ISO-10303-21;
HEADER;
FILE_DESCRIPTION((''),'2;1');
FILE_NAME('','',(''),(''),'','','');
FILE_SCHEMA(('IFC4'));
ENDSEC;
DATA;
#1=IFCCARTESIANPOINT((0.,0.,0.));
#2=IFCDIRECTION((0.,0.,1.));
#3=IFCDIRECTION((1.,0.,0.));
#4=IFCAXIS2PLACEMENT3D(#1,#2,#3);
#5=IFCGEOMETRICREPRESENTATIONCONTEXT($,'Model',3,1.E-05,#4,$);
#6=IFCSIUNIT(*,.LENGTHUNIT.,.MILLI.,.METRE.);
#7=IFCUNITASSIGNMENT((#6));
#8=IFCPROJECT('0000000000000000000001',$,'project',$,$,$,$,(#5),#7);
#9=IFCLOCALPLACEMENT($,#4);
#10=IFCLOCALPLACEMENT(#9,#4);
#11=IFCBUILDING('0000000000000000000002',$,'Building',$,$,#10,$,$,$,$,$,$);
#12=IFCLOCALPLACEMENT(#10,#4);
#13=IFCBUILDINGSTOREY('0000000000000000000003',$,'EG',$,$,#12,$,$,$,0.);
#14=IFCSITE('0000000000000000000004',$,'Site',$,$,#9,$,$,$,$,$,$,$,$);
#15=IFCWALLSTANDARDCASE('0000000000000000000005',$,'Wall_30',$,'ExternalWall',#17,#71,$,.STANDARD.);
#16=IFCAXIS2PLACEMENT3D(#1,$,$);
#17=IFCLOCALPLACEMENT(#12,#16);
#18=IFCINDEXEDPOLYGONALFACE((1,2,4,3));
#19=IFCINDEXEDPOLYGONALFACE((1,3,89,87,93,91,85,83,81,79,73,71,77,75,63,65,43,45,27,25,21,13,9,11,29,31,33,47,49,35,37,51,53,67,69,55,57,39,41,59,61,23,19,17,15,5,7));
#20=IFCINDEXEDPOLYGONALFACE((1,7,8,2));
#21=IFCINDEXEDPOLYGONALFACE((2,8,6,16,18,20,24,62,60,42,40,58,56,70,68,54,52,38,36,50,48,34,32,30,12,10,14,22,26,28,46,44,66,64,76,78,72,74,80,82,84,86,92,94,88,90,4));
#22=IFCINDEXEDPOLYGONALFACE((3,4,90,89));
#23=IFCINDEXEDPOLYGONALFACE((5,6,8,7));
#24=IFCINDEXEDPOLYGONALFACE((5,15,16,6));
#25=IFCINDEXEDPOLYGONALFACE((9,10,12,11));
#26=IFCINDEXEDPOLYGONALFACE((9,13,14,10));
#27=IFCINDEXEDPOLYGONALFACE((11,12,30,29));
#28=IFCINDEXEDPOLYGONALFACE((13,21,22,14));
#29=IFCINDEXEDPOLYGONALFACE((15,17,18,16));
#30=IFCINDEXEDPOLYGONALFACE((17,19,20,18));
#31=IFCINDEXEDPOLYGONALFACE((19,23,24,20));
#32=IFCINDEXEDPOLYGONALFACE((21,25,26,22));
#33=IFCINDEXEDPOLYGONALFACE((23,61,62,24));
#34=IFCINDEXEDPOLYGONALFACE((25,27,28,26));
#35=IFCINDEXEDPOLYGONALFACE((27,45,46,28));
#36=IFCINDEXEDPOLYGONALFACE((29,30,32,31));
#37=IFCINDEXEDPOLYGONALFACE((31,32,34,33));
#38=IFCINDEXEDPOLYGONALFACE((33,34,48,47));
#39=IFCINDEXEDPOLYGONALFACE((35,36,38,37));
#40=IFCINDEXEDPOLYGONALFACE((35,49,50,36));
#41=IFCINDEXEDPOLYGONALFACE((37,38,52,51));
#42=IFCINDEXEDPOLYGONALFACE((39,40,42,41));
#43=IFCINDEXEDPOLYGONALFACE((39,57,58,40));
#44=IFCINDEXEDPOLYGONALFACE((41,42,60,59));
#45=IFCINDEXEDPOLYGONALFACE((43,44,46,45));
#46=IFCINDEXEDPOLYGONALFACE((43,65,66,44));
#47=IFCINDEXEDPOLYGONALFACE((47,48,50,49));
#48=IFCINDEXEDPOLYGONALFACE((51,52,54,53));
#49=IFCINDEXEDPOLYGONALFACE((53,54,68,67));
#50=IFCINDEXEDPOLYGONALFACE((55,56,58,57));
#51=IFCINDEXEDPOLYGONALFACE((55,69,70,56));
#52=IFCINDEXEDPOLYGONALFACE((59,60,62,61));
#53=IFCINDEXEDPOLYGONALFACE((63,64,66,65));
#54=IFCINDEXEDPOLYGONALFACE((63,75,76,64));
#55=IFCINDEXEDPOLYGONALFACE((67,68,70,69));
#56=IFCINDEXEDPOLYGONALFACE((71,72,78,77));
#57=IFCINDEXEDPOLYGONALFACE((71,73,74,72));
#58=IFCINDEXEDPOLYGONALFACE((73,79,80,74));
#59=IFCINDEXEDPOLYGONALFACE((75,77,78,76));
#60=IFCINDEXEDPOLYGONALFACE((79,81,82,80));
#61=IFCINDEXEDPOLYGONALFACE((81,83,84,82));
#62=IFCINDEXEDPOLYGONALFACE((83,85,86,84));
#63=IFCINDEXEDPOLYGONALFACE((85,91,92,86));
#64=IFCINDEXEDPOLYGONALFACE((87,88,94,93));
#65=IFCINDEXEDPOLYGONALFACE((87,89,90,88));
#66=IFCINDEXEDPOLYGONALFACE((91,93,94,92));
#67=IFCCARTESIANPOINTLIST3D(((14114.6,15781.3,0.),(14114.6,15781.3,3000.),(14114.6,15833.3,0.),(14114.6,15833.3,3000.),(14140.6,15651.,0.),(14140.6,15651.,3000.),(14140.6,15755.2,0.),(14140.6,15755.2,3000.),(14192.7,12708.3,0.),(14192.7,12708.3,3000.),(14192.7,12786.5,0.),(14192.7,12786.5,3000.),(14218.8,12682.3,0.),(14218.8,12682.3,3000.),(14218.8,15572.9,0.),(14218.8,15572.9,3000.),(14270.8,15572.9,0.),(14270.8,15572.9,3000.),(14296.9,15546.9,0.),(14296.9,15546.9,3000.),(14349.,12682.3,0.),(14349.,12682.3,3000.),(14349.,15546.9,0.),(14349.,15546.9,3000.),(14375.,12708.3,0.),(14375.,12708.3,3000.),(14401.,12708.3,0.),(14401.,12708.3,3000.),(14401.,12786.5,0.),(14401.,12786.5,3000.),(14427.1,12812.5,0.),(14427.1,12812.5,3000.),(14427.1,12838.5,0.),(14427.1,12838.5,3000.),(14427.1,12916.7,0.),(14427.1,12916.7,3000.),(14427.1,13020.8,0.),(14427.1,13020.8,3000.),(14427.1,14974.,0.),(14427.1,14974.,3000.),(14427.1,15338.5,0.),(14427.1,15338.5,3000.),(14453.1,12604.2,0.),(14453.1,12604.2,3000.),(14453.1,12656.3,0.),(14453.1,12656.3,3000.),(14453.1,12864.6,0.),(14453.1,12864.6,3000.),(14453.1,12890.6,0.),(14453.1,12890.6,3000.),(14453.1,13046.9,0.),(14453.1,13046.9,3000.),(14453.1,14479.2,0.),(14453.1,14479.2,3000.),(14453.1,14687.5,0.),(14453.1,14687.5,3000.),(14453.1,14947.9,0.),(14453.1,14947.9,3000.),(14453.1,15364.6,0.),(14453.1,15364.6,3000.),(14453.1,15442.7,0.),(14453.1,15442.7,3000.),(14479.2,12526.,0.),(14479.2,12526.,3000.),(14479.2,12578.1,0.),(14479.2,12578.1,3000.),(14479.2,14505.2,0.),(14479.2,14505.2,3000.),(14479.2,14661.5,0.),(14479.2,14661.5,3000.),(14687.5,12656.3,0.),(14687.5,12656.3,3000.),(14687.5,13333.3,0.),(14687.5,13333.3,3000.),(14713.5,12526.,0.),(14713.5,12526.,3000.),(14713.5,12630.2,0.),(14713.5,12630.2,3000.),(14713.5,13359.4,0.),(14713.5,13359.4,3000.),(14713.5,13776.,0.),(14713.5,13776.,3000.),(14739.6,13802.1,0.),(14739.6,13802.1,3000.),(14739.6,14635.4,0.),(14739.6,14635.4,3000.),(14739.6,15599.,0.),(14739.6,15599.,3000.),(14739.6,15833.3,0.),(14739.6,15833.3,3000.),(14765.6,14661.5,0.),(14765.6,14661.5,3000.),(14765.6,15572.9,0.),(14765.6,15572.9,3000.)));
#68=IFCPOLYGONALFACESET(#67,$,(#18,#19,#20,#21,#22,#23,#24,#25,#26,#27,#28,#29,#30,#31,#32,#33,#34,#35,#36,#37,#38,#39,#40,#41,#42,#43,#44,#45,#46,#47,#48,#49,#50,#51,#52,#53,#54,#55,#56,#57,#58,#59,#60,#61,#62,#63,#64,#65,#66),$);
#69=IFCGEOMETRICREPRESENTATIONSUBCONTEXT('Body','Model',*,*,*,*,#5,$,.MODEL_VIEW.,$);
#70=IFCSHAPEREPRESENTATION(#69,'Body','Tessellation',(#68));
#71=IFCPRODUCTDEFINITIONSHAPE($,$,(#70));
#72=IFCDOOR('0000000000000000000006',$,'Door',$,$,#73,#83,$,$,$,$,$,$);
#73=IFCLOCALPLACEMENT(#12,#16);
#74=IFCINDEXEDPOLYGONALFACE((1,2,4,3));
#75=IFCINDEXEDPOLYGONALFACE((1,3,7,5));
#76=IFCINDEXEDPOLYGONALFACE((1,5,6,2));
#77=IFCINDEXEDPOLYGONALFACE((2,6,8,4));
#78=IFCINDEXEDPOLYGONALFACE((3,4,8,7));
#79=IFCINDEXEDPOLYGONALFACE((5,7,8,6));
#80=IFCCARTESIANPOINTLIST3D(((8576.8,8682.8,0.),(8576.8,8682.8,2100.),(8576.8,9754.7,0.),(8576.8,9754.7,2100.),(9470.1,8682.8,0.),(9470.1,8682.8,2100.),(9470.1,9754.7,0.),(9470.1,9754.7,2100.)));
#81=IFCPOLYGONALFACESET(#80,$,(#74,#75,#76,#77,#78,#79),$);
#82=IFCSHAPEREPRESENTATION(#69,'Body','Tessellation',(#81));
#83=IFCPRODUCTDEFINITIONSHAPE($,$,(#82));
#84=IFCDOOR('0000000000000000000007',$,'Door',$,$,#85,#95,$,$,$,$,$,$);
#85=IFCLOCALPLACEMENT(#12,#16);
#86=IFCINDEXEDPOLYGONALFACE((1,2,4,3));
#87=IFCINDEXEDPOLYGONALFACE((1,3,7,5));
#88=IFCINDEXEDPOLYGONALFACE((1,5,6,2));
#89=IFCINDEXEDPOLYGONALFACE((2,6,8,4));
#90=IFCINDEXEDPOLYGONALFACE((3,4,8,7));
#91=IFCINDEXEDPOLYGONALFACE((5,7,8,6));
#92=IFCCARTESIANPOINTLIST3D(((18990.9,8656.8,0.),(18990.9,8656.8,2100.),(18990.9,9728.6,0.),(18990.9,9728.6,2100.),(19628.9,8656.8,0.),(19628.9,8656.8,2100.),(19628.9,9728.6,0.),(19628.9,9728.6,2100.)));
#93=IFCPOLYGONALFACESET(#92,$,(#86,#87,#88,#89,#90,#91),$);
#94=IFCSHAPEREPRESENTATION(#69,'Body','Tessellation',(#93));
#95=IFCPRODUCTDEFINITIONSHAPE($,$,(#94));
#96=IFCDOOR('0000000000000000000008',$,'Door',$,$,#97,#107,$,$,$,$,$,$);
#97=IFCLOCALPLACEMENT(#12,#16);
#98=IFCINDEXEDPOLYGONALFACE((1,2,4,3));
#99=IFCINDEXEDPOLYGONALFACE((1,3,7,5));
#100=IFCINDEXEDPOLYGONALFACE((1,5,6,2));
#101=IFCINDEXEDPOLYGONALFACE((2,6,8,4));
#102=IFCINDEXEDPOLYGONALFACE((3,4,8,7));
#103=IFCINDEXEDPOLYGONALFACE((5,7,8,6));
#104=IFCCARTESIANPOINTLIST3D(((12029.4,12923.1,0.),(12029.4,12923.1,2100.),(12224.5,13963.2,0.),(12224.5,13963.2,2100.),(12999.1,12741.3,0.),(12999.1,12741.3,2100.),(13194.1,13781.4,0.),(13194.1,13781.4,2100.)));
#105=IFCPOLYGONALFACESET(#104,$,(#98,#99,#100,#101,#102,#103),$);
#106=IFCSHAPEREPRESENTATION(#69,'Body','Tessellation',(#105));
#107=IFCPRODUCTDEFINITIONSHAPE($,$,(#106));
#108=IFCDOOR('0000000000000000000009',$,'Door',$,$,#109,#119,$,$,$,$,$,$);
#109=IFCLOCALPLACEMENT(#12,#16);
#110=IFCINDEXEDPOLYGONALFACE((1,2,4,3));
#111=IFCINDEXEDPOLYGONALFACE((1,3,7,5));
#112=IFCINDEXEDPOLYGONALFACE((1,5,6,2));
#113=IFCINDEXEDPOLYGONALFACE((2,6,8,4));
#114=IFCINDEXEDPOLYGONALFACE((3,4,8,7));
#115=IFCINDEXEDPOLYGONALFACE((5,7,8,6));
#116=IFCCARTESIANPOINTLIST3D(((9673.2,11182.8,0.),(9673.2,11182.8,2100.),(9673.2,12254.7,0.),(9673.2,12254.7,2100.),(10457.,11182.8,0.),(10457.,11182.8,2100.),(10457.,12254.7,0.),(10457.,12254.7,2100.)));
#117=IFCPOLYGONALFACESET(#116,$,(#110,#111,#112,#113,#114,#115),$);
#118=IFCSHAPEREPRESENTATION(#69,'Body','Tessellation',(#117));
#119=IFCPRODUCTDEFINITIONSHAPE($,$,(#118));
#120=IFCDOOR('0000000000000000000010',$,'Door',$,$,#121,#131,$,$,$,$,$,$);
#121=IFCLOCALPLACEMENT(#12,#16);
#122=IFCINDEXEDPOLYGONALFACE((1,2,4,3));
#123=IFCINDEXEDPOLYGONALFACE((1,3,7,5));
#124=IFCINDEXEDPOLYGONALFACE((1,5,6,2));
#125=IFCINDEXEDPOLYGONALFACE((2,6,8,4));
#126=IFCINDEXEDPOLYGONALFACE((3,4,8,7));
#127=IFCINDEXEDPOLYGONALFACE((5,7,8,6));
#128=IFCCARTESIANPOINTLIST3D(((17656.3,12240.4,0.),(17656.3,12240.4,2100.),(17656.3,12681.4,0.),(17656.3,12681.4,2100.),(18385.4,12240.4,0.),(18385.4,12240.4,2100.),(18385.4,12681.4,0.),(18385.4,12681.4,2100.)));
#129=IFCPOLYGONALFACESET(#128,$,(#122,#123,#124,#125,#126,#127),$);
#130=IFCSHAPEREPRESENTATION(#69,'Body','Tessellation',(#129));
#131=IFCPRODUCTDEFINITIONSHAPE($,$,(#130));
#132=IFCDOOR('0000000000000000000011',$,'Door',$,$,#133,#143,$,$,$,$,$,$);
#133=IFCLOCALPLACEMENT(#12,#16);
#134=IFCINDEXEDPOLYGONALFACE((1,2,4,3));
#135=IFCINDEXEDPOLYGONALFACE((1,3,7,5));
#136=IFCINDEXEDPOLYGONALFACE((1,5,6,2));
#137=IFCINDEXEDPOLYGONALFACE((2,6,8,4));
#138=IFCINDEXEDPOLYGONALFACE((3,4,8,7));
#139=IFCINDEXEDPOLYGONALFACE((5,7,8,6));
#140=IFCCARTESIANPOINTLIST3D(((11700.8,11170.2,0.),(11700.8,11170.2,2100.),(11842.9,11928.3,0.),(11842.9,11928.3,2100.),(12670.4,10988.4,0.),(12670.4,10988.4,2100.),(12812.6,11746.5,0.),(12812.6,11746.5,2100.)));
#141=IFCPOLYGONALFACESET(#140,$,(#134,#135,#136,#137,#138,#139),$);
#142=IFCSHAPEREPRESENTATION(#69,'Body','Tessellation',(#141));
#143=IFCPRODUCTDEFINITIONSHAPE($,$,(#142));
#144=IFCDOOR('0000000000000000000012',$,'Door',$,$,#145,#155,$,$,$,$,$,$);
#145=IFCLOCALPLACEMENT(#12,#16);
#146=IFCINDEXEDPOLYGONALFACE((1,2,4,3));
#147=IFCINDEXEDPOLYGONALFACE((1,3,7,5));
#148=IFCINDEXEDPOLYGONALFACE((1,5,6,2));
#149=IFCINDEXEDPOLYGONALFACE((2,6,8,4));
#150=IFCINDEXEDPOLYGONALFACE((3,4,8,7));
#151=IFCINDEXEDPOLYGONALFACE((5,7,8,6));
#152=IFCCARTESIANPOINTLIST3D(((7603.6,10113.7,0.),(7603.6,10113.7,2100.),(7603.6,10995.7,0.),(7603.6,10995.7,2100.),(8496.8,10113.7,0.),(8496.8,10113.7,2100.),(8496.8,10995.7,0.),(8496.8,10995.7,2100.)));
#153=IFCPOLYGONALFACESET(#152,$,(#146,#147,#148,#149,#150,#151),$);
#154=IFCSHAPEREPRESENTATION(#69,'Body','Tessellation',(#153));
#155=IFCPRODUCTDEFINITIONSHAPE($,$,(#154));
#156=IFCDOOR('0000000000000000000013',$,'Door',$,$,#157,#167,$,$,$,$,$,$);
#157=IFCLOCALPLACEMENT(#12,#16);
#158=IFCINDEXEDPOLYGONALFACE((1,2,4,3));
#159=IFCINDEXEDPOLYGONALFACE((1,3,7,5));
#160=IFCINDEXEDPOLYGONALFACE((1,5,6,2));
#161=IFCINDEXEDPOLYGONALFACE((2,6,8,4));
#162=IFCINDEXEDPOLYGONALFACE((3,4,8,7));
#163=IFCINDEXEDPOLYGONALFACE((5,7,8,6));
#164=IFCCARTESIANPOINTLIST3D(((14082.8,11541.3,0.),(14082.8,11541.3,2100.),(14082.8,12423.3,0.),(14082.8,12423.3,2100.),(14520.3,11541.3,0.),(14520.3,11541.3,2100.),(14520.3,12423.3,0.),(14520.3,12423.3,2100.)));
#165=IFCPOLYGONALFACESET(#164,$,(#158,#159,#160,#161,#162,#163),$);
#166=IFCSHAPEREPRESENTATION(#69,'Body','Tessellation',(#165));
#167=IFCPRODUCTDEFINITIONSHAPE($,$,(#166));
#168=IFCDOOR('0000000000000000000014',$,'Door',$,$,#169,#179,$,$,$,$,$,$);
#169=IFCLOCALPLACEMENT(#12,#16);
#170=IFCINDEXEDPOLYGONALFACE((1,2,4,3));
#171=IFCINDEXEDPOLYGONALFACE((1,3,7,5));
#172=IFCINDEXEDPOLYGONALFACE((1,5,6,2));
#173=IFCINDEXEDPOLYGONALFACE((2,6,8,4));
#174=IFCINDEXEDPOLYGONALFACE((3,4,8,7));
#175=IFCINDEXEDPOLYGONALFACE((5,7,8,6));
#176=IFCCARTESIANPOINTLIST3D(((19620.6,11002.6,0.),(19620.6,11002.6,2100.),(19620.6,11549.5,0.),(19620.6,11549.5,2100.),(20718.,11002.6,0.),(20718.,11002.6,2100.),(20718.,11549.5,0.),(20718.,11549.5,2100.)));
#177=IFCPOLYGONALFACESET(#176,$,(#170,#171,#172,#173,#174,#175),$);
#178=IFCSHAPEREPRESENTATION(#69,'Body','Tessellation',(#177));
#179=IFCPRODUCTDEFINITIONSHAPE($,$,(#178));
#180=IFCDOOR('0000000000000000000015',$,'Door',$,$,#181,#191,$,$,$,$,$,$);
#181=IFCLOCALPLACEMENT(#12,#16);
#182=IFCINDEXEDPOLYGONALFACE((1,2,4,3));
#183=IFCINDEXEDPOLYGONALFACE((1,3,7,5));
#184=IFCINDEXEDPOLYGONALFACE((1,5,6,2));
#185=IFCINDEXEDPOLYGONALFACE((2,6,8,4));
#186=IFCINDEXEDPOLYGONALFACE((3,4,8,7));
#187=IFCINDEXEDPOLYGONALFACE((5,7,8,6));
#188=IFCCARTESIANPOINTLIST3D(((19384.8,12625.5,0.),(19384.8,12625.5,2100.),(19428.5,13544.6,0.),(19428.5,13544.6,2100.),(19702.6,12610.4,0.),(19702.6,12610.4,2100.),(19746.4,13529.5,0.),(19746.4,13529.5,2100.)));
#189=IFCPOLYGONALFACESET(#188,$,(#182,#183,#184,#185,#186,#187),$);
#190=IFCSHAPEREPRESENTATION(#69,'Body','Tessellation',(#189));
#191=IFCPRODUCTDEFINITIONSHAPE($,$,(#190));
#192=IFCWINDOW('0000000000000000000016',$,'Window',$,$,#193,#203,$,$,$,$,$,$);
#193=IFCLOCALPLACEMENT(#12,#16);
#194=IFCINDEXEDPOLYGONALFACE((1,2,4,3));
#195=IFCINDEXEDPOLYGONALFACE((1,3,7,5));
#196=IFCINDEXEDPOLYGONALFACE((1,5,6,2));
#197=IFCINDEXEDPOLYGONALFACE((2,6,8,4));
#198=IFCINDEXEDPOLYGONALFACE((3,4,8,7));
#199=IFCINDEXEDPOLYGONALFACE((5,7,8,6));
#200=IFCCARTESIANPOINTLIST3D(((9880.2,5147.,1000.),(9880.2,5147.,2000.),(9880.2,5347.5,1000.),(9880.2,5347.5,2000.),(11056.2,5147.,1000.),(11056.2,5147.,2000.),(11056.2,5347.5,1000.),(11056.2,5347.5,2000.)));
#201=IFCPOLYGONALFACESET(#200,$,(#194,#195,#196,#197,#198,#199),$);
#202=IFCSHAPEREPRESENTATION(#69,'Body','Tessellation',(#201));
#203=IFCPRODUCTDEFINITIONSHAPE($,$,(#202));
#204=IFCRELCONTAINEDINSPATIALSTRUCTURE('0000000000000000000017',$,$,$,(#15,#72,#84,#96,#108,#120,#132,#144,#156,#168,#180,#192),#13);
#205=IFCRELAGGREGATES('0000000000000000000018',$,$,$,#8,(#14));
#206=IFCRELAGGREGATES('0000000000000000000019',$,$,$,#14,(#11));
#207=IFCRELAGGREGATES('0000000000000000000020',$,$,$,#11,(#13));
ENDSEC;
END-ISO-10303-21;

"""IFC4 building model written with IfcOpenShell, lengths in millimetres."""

from ifc_helpers import new_model, si_unit, frame, origin_with_axes, place, context, subcontext, project, spatial, polyline, rectangle, outline, extrude, element, save


model = new_model("IFC4")

# Units and contexts
model_context = context("Model", 3, precision=1e-05, world=origin_with_axes())
body_context = subcontext(model_context, "Body", "Model", "MODEL_VIEW")
ifc_project = project(units=[si_unit("LENGTHUNIT", "METRE", prefix="MILLI")], contexts=[model_context])

# Site, building, storey
site_placement = place(None, origin_with_axes())
site = spatial("IfcSite", under=ifc_project, at=site_placement, Name="Site")
building_placement = place(site_placement, origin_with_axes())
building = spatial("IfcBuilding", under=site, at=building_placement, Name="Building")
storey_placement = place(building_placement, origin_with_axes())
storey = spatial("IfcBuildingStorey", under=building, at=storey_placement, Name="EG", Elevation=0.0)

# Wall
wall_placement = place(storey_placement, origin_with_axes())
element("IfcWallStandardCase", 1, at=wall_placement, inside=storey, Name="Wall_30", ObjectType="ExternalWall", PredefinedType="STANDARD", context=body_context, shape_type="SweptSolid", body=[
    extrude(outline(polyline([(14479.2, 12526.0, 0.0), (14479.2, 12578.1, 0.0), (14453.1, 12604.2, 0.0), (14453.1, 12656.3, 0.0), (14401.0, 12708.3, 0.0), (14375.0, 12708.3, 0.0), (14349.0, 12682.3, 0.0), (14218.8, 12682.3, 0.0), (14192.7, 12708.3, 0.0), (14192.7, 12786.5, 0.0), (14401.0, 12786.5, 0.0), (14427.1, 12812.5, 0.0), (14427.1, 12838.5, 0.0), (14453.1, 12864.6, 0.0), (14453.1, 12890.6, 0.0), (14427.1, 12916.7, 0.0), (14427.1, 13020.8, 0.0), (14453.1, 13046.9, 0.0), (14453.1, 14479.2, 0.0), (14479.2, 14505.2, 0.0), (14479.2, 14661.5, 0.0), (14453.1, 14687.5, 0.0), (14453.1, 14947.9, 0.0), (14427.1, 14974.0, 0.0), (14427.1, 15338.5, 0.0), (14453.1, 15364.6, 0.0), (14453.1, 15442.7, 0.0), (14349.0, 15546.9, 0.0), (14296.9, 15546.9, 0.0), (14270.8, 15572.9, 0.0), (14218.8, 15572.9, 0.0), (14140.6, 15651.0, 0.0), (14140.6, 15755.2, 0.0), (14114.6, 15781.3, 0.0), (14114.6, 15833.3, 0.0), (14739.6, 15833.3, 0.0), (14739.6, 15599.0, 0.0), (14765.6, 15572.9, 0.0), (14765.6, 14661.5, 0.0), (14739.6, 14635.4, 0.0), (14739.6, 13802.1, 0.0), (14713.5, 13776.0, 0.0), (14713.5, 13359.4, 0.0), (14687.5, 13333.3, 0.0), (14687.5, 12656.3, 0.0), (14713.5, 12630.2, 0.0), (14713.5, 12526.0, 0.0), (14479.2, 12526.0, 0.0)])), origin_with_axes(), (0.0, 0.0, 1.0), 3000.0),
])

# Doors
door_1_placement = place(storey_placement, origin_with_axes())
element("IfcDoor", 2, at=door_1_placement, inside=storey, Name="Door", context=body_context, shape_type="SweptSolid", body=[
    extrude(rectangle(XDim=1071.9, YDim=893.2), frame((9023.4, 9218.8, 0.0), z_axis=(0.0, 0.0, 1.0), x_axis=(0.0, 1.0, 0.0)), (0.0, 0.0, 1.0), 2100.0),
])
door_2_placement = place(storey_placement, origin_with_axes())
element("IfcDoor", 3, at=door_2_placement, inside=storey, Name="Door", context=body_context, shape_type="SweptSolid", body=[
    extrude(rectangle(XDim=1071.9, YDim=638.0), frame((19309.9, 9192.7, 0.0), z_axis=(0.0, 0.0, 1.0), x_axis=(0.0, 1.0, 0.0)), (0.0, 0.0, 1.0), 2100.0),
])
door_3_placement = place(storey_placement, origin_with_axes())
element("IfcDoor", 4, at=door_3_placement, inside=storey, Name="Door", context=body_context, shape_type="SweptSolid", body=[
    extrude(rectangle(XDim=1058.2, YDim=986.6), frame((12611.8, 13352.3, 0.0), z_axis=(0.0, 0.0, 1.0), x_axis=(0.184288, 0.982872, 0.0)), (0.0, 0.0, 1.0), 2100.0),
])
door_4_placement = place(storey_placement, origin_with_axes())
element("IfcDoor", 5, at=door_4_placement, inside=storey, Name="Door", context=body_context, shape_type="SweptSolid", body=[
    extrude(rectangle(XDim=1071.9, YDim=783.9), frame((10065.1, 11718.8, 0.0), z_axis=(0.0, 0.0, 1.0), x_axis=(0.0, -1.0, 0.0)), (0.0, 0.0, 1.0), 2100.0),
])
door_5_placement = place(storey_placement, origin_with_axes())
element("IfcDoor", 6, at=door_5_placement, inside=storey, Name="Door", context=body_context, shape_type="SweptSolid", body=[
    extrude(rectangle(XDim=441.0, YDim=729.2), frame((18020.8, 12460.9, 0.0), z_axis=(0.0, 0.0, 1.0), x_axis=(0.0, 1.0, 0.0)), (0.0, 0.0, 1.0), 2100.0),
])
door_6_placement = place(storey_placement, origin_with_axes())
element("IfcDoor", 7, at=door_6_placement, inside=storey, Name="Door", context=body_context, shape_type="SweptSolid", body=[
    extrude(rectangle(XDim=771.3, YDim=986.6), frame((12256.7, 11458.4, 0.0), z_axis=(0.0, 0.0, 1.0), x_axis=(0.184288, 0.982872, 0.0)), (0.0, 0.0, 1.0), 2100.0),
])
door_7_placement = place(storey_placement, origin_with_axes())
element("IfcDoor", 8, at=door_7_placement, inside=storey, Name="Door", context=body_context, shape_type="SweptSolid", body=[
    extrude(rectangle(XDim=882.0, YDim=893.2), frame((8050.2, 10554.7, 0.0), z_axis=(0.0, 0.0, 1.0), x_axis=(0.0, 1.0, 0.0)), (0.0, 0.0, 1.0), 2100.0),
])
door_8_placement = place(storey_placement, origin_with_axes())
element("IfcDoor", 9, at=door_8_placement, inside=storey, Name="Door", context=body_context, shape_type="SweptSolid", body=[
    extrude(rectangle(XDim=882.0, YDim=437.5), frame((14301.5, 11982.3, 0.0), z_axis=(0.0, 0.0, 1.0), x_axis=(0.0, 1.0, 0.0)), (0.0, 0.0, 1.0), 2100.0),
])
door_9_placement = place(storey_placement, origin_with_axes())
element("IfcDoor", 10, at=door_9_placement, inside=storey, Name="Door", context=body_context, shape_type="SweptSolid", body=[
    extrude(rectangle(XDim=1097.4, YDim=546.9), frame((20169.3, 11276.0, 0.0), z_axis=(0.0, 0.0, 1.0), x_axis=(1.0, 0.0, 0.0)), (0.0, 0.0, 1.0), 2100.0),
])
door_10_placement = place(storey_placement, origin_with_axes())
element("IfcDoor", 11, at=door_10_placement, inside=storey, Name="Door", context=body_context, shape_type="SweptSolid", body=[
    extrude(rectangle(XDim=920.1, YDim=318.2), frame((19565.6, 13077.5, 0.0), z_axis=(0.0, 0.0, 1.0), x_axis=(-0.047565, -0.998868, 0.0)), (0.0, 0.0, 1.0), 2100.0),
])

# Window
window_1_placement = place(storey_placement, origin_with_axes())
element("IfcWindow", 12, at=window_1_placement, inside=storey, Name="Window", context=body_context, shape_type="SweptSolid", body=[
    extrude(rectangle(XDim=1176.0, YDim=200.5), frame((10468.2, 5247.3, 1000.0), z_axis=(0.0, 0.0, 1.0), x_axis=(-1.0, 0.0, 0.0)), (0.0, 0.0, 1.0), 1000.0),
])

save(model, "model.ifc")
